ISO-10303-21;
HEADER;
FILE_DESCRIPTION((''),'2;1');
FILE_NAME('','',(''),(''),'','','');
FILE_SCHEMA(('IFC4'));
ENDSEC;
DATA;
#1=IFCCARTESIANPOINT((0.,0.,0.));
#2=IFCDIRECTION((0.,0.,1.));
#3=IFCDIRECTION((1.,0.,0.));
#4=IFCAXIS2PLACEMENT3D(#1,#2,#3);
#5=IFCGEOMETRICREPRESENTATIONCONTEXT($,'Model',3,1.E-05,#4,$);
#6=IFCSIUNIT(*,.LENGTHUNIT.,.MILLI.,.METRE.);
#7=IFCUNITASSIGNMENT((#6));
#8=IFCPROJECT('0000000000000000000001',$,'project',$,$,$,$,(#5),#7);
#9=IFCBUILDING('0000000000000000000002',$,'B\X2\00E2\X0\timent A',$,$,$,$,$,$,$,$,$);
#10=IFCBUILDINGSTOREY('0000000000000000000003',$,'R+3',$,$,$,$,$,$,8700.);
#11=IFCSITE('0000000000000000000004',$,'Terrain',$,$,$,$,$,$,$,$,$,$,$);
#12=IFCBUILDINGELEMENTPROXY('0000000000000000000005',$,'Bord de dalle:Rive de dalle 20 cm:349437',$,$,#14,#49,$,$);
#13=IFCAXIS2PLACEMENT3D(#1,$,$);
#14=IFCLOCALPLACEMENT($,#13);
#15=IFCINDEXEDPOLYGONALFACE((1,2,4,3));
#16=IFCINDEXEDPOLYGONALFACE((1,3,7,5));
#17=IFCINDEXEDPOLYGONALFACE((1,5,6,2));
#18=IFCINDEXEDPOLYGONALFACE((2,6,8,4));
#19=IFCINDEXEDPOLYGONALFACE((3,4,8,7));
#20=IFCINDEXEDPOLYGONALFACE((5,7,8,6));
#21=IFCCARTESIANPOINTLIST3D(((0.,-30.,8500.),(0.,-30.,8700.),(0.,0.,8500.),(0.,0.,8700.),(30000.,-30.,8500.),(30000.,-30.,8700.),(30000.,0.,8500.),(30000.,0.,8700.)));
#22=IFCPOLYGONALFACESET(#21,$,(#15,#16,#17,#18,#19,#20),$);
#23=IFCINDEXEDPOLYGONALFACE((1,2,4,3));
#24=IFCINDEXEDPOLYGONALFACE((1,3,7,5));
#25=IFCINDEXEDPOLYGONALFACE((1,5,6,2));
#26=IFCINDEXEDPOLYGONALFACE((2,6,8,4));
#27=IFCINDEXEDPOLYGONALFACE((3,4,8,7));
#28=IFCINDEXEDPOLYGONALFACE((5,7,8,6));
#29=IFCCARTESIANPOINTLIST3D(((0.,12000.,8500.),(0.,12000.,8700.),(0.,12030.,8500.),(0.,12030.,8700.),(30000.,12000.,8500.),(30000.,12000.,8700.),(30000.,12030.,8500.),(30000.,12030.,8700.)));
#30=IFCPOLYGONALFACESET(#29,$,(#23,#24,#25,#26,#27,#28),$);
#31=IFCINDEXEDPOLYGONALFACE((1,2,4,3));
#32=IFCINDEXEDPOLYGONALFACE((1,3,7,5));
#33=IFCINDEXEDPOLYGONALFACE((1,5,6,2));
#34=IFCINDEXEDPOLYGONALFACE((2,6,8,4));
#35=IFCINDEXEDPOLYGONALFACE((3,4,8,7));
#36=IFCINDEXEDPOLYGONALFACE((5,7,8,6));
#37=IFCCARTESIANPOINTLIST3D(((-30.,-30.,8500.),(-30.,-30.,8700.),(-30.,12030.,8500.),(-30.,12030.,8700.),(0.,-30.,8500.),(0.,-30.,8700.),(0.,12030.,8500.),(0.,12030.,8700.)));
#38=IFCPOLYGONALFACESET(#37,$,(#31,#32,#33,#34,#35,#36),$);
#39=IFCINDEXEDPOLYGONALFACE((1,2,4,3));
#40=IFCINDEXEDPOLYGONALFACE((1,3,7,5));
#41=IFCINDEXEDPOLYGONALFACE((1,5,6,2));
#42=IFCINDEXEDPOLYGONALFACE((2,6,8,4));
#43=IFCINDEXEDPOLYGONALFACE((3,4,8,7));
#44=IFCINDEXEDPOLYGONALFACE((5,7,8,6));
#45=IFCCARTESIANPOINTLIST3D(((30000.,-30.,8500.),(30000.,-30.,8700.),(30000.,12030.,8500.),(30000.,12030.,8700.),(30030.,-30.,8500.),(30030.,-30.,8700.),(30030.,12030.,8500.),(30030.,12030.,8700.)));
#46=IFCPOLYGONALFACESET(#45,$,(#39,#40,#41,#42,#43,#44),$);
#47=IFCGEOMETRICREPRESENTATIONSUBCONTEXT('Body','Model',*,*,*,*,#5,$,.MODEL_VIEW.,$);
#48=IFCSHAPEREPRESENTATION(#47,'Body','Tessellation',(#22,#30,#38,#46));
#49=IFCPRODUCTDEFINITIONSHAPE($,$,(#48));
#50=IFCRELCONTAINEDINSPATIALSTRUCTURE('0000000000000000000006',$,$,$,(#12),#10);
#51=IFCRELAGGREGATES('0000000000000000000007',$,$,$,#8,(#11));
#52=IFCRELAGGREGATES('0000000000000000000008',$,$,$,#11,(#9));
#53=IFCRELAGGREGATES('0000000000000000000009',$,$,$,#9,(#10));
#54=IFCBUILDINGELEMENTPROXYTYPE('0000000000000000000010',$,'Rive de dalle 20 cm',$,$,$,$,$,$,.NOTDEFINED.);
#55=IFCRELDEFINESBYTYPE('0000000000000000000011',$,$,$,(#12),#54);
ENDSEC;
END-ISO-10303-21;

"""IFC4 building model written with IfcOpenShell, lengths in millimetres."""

from ifc_helpers import new_model, si_unit, frame, frame_2d, origin_with_axes, place, context, subcontext, project, spatial, rectangle, extrude, type_object, element, save


model = new_model("IFC4")

# Units and contexts
model_context = context("Model", 3, precision=1e-05, world=origin_with_axes())
body_context = subcontext(model_context, "Body", "Model", "MODEL_VIEW")
ifc_project = project(units=[si_unit("LENGTHUNIT", "METRE", prefix="MILLI")], contexts=[model_context])

# Site, building, storey
site = spatial("IfcSite", under=ifc_project, Name="Terrain")
building = spatial("IfcBuilding", under=site, Name="Bâtiment A")
storey = spatial("IfcBuildingStorey", under=building, Name="R+3", Elevation=8700.0)

# Building element proxy
building_element_proxy_type = type_object("IfcBuildingElementProxyType", Name="Rive de dalle 20 cm", PredefinedType="NOTDEFINED")
proxy_placement = place(None, origin_with_axes())
element("IfcBuildingElementProxy", 1, at=proxy_placement, inside=storey, type_object=building_element_proxy_type, Name="Bord de dalle:Rive de dalle 20 cm:349437", context=body_context, shape_type="SweptSolid", body=[
    extrude(rectangle(XDim=30000.0, YDim=30.0, at=frame_2d((15000.0, -15.0))), frame((0.0, 0.0, 8500.0), z_axis=(0.0, 0.0, 1.0), x_axis=(1.0, 0.0, 0.0)), (0.0, 0.0, 1.0), 200.0),
    extrude(rectangle(XDim=30000.0, YDim=30.0, at=frame_2d((15000.0, 12015.0))), frame((0.0, 0.0, 8500.0), z_axis=(0.0, 0.0, 1.0), x_axis=(1.0, 0.0, 0.0)), (0.0, 0.0, 1.0), 200.0),
    extrude(rectangle(XDim=30.0, YDim=12060.0, at=frame_2d((-15.0, 6000.0))), frame((0.0, 0.0, 8500.0), z_axis=(0.0, 0.0, 1.0), x_axis=(1.0, 0.0, 0.0)), (0.0, 0.0, 1.0), 200.0),
    extrude(rectangle(XDim=30.0, YDim=12060.0, at=frame_2d((30015.0, 6000.0))), frame((0.0, 0.0, 8500.0), z_axis=(0.0, 0.0, 1.0), x_axis=(1.0, 0.0, 0.0)), (0.0, 0.0, 1.0), 200.0),
])

save(model, "model.ifc")
